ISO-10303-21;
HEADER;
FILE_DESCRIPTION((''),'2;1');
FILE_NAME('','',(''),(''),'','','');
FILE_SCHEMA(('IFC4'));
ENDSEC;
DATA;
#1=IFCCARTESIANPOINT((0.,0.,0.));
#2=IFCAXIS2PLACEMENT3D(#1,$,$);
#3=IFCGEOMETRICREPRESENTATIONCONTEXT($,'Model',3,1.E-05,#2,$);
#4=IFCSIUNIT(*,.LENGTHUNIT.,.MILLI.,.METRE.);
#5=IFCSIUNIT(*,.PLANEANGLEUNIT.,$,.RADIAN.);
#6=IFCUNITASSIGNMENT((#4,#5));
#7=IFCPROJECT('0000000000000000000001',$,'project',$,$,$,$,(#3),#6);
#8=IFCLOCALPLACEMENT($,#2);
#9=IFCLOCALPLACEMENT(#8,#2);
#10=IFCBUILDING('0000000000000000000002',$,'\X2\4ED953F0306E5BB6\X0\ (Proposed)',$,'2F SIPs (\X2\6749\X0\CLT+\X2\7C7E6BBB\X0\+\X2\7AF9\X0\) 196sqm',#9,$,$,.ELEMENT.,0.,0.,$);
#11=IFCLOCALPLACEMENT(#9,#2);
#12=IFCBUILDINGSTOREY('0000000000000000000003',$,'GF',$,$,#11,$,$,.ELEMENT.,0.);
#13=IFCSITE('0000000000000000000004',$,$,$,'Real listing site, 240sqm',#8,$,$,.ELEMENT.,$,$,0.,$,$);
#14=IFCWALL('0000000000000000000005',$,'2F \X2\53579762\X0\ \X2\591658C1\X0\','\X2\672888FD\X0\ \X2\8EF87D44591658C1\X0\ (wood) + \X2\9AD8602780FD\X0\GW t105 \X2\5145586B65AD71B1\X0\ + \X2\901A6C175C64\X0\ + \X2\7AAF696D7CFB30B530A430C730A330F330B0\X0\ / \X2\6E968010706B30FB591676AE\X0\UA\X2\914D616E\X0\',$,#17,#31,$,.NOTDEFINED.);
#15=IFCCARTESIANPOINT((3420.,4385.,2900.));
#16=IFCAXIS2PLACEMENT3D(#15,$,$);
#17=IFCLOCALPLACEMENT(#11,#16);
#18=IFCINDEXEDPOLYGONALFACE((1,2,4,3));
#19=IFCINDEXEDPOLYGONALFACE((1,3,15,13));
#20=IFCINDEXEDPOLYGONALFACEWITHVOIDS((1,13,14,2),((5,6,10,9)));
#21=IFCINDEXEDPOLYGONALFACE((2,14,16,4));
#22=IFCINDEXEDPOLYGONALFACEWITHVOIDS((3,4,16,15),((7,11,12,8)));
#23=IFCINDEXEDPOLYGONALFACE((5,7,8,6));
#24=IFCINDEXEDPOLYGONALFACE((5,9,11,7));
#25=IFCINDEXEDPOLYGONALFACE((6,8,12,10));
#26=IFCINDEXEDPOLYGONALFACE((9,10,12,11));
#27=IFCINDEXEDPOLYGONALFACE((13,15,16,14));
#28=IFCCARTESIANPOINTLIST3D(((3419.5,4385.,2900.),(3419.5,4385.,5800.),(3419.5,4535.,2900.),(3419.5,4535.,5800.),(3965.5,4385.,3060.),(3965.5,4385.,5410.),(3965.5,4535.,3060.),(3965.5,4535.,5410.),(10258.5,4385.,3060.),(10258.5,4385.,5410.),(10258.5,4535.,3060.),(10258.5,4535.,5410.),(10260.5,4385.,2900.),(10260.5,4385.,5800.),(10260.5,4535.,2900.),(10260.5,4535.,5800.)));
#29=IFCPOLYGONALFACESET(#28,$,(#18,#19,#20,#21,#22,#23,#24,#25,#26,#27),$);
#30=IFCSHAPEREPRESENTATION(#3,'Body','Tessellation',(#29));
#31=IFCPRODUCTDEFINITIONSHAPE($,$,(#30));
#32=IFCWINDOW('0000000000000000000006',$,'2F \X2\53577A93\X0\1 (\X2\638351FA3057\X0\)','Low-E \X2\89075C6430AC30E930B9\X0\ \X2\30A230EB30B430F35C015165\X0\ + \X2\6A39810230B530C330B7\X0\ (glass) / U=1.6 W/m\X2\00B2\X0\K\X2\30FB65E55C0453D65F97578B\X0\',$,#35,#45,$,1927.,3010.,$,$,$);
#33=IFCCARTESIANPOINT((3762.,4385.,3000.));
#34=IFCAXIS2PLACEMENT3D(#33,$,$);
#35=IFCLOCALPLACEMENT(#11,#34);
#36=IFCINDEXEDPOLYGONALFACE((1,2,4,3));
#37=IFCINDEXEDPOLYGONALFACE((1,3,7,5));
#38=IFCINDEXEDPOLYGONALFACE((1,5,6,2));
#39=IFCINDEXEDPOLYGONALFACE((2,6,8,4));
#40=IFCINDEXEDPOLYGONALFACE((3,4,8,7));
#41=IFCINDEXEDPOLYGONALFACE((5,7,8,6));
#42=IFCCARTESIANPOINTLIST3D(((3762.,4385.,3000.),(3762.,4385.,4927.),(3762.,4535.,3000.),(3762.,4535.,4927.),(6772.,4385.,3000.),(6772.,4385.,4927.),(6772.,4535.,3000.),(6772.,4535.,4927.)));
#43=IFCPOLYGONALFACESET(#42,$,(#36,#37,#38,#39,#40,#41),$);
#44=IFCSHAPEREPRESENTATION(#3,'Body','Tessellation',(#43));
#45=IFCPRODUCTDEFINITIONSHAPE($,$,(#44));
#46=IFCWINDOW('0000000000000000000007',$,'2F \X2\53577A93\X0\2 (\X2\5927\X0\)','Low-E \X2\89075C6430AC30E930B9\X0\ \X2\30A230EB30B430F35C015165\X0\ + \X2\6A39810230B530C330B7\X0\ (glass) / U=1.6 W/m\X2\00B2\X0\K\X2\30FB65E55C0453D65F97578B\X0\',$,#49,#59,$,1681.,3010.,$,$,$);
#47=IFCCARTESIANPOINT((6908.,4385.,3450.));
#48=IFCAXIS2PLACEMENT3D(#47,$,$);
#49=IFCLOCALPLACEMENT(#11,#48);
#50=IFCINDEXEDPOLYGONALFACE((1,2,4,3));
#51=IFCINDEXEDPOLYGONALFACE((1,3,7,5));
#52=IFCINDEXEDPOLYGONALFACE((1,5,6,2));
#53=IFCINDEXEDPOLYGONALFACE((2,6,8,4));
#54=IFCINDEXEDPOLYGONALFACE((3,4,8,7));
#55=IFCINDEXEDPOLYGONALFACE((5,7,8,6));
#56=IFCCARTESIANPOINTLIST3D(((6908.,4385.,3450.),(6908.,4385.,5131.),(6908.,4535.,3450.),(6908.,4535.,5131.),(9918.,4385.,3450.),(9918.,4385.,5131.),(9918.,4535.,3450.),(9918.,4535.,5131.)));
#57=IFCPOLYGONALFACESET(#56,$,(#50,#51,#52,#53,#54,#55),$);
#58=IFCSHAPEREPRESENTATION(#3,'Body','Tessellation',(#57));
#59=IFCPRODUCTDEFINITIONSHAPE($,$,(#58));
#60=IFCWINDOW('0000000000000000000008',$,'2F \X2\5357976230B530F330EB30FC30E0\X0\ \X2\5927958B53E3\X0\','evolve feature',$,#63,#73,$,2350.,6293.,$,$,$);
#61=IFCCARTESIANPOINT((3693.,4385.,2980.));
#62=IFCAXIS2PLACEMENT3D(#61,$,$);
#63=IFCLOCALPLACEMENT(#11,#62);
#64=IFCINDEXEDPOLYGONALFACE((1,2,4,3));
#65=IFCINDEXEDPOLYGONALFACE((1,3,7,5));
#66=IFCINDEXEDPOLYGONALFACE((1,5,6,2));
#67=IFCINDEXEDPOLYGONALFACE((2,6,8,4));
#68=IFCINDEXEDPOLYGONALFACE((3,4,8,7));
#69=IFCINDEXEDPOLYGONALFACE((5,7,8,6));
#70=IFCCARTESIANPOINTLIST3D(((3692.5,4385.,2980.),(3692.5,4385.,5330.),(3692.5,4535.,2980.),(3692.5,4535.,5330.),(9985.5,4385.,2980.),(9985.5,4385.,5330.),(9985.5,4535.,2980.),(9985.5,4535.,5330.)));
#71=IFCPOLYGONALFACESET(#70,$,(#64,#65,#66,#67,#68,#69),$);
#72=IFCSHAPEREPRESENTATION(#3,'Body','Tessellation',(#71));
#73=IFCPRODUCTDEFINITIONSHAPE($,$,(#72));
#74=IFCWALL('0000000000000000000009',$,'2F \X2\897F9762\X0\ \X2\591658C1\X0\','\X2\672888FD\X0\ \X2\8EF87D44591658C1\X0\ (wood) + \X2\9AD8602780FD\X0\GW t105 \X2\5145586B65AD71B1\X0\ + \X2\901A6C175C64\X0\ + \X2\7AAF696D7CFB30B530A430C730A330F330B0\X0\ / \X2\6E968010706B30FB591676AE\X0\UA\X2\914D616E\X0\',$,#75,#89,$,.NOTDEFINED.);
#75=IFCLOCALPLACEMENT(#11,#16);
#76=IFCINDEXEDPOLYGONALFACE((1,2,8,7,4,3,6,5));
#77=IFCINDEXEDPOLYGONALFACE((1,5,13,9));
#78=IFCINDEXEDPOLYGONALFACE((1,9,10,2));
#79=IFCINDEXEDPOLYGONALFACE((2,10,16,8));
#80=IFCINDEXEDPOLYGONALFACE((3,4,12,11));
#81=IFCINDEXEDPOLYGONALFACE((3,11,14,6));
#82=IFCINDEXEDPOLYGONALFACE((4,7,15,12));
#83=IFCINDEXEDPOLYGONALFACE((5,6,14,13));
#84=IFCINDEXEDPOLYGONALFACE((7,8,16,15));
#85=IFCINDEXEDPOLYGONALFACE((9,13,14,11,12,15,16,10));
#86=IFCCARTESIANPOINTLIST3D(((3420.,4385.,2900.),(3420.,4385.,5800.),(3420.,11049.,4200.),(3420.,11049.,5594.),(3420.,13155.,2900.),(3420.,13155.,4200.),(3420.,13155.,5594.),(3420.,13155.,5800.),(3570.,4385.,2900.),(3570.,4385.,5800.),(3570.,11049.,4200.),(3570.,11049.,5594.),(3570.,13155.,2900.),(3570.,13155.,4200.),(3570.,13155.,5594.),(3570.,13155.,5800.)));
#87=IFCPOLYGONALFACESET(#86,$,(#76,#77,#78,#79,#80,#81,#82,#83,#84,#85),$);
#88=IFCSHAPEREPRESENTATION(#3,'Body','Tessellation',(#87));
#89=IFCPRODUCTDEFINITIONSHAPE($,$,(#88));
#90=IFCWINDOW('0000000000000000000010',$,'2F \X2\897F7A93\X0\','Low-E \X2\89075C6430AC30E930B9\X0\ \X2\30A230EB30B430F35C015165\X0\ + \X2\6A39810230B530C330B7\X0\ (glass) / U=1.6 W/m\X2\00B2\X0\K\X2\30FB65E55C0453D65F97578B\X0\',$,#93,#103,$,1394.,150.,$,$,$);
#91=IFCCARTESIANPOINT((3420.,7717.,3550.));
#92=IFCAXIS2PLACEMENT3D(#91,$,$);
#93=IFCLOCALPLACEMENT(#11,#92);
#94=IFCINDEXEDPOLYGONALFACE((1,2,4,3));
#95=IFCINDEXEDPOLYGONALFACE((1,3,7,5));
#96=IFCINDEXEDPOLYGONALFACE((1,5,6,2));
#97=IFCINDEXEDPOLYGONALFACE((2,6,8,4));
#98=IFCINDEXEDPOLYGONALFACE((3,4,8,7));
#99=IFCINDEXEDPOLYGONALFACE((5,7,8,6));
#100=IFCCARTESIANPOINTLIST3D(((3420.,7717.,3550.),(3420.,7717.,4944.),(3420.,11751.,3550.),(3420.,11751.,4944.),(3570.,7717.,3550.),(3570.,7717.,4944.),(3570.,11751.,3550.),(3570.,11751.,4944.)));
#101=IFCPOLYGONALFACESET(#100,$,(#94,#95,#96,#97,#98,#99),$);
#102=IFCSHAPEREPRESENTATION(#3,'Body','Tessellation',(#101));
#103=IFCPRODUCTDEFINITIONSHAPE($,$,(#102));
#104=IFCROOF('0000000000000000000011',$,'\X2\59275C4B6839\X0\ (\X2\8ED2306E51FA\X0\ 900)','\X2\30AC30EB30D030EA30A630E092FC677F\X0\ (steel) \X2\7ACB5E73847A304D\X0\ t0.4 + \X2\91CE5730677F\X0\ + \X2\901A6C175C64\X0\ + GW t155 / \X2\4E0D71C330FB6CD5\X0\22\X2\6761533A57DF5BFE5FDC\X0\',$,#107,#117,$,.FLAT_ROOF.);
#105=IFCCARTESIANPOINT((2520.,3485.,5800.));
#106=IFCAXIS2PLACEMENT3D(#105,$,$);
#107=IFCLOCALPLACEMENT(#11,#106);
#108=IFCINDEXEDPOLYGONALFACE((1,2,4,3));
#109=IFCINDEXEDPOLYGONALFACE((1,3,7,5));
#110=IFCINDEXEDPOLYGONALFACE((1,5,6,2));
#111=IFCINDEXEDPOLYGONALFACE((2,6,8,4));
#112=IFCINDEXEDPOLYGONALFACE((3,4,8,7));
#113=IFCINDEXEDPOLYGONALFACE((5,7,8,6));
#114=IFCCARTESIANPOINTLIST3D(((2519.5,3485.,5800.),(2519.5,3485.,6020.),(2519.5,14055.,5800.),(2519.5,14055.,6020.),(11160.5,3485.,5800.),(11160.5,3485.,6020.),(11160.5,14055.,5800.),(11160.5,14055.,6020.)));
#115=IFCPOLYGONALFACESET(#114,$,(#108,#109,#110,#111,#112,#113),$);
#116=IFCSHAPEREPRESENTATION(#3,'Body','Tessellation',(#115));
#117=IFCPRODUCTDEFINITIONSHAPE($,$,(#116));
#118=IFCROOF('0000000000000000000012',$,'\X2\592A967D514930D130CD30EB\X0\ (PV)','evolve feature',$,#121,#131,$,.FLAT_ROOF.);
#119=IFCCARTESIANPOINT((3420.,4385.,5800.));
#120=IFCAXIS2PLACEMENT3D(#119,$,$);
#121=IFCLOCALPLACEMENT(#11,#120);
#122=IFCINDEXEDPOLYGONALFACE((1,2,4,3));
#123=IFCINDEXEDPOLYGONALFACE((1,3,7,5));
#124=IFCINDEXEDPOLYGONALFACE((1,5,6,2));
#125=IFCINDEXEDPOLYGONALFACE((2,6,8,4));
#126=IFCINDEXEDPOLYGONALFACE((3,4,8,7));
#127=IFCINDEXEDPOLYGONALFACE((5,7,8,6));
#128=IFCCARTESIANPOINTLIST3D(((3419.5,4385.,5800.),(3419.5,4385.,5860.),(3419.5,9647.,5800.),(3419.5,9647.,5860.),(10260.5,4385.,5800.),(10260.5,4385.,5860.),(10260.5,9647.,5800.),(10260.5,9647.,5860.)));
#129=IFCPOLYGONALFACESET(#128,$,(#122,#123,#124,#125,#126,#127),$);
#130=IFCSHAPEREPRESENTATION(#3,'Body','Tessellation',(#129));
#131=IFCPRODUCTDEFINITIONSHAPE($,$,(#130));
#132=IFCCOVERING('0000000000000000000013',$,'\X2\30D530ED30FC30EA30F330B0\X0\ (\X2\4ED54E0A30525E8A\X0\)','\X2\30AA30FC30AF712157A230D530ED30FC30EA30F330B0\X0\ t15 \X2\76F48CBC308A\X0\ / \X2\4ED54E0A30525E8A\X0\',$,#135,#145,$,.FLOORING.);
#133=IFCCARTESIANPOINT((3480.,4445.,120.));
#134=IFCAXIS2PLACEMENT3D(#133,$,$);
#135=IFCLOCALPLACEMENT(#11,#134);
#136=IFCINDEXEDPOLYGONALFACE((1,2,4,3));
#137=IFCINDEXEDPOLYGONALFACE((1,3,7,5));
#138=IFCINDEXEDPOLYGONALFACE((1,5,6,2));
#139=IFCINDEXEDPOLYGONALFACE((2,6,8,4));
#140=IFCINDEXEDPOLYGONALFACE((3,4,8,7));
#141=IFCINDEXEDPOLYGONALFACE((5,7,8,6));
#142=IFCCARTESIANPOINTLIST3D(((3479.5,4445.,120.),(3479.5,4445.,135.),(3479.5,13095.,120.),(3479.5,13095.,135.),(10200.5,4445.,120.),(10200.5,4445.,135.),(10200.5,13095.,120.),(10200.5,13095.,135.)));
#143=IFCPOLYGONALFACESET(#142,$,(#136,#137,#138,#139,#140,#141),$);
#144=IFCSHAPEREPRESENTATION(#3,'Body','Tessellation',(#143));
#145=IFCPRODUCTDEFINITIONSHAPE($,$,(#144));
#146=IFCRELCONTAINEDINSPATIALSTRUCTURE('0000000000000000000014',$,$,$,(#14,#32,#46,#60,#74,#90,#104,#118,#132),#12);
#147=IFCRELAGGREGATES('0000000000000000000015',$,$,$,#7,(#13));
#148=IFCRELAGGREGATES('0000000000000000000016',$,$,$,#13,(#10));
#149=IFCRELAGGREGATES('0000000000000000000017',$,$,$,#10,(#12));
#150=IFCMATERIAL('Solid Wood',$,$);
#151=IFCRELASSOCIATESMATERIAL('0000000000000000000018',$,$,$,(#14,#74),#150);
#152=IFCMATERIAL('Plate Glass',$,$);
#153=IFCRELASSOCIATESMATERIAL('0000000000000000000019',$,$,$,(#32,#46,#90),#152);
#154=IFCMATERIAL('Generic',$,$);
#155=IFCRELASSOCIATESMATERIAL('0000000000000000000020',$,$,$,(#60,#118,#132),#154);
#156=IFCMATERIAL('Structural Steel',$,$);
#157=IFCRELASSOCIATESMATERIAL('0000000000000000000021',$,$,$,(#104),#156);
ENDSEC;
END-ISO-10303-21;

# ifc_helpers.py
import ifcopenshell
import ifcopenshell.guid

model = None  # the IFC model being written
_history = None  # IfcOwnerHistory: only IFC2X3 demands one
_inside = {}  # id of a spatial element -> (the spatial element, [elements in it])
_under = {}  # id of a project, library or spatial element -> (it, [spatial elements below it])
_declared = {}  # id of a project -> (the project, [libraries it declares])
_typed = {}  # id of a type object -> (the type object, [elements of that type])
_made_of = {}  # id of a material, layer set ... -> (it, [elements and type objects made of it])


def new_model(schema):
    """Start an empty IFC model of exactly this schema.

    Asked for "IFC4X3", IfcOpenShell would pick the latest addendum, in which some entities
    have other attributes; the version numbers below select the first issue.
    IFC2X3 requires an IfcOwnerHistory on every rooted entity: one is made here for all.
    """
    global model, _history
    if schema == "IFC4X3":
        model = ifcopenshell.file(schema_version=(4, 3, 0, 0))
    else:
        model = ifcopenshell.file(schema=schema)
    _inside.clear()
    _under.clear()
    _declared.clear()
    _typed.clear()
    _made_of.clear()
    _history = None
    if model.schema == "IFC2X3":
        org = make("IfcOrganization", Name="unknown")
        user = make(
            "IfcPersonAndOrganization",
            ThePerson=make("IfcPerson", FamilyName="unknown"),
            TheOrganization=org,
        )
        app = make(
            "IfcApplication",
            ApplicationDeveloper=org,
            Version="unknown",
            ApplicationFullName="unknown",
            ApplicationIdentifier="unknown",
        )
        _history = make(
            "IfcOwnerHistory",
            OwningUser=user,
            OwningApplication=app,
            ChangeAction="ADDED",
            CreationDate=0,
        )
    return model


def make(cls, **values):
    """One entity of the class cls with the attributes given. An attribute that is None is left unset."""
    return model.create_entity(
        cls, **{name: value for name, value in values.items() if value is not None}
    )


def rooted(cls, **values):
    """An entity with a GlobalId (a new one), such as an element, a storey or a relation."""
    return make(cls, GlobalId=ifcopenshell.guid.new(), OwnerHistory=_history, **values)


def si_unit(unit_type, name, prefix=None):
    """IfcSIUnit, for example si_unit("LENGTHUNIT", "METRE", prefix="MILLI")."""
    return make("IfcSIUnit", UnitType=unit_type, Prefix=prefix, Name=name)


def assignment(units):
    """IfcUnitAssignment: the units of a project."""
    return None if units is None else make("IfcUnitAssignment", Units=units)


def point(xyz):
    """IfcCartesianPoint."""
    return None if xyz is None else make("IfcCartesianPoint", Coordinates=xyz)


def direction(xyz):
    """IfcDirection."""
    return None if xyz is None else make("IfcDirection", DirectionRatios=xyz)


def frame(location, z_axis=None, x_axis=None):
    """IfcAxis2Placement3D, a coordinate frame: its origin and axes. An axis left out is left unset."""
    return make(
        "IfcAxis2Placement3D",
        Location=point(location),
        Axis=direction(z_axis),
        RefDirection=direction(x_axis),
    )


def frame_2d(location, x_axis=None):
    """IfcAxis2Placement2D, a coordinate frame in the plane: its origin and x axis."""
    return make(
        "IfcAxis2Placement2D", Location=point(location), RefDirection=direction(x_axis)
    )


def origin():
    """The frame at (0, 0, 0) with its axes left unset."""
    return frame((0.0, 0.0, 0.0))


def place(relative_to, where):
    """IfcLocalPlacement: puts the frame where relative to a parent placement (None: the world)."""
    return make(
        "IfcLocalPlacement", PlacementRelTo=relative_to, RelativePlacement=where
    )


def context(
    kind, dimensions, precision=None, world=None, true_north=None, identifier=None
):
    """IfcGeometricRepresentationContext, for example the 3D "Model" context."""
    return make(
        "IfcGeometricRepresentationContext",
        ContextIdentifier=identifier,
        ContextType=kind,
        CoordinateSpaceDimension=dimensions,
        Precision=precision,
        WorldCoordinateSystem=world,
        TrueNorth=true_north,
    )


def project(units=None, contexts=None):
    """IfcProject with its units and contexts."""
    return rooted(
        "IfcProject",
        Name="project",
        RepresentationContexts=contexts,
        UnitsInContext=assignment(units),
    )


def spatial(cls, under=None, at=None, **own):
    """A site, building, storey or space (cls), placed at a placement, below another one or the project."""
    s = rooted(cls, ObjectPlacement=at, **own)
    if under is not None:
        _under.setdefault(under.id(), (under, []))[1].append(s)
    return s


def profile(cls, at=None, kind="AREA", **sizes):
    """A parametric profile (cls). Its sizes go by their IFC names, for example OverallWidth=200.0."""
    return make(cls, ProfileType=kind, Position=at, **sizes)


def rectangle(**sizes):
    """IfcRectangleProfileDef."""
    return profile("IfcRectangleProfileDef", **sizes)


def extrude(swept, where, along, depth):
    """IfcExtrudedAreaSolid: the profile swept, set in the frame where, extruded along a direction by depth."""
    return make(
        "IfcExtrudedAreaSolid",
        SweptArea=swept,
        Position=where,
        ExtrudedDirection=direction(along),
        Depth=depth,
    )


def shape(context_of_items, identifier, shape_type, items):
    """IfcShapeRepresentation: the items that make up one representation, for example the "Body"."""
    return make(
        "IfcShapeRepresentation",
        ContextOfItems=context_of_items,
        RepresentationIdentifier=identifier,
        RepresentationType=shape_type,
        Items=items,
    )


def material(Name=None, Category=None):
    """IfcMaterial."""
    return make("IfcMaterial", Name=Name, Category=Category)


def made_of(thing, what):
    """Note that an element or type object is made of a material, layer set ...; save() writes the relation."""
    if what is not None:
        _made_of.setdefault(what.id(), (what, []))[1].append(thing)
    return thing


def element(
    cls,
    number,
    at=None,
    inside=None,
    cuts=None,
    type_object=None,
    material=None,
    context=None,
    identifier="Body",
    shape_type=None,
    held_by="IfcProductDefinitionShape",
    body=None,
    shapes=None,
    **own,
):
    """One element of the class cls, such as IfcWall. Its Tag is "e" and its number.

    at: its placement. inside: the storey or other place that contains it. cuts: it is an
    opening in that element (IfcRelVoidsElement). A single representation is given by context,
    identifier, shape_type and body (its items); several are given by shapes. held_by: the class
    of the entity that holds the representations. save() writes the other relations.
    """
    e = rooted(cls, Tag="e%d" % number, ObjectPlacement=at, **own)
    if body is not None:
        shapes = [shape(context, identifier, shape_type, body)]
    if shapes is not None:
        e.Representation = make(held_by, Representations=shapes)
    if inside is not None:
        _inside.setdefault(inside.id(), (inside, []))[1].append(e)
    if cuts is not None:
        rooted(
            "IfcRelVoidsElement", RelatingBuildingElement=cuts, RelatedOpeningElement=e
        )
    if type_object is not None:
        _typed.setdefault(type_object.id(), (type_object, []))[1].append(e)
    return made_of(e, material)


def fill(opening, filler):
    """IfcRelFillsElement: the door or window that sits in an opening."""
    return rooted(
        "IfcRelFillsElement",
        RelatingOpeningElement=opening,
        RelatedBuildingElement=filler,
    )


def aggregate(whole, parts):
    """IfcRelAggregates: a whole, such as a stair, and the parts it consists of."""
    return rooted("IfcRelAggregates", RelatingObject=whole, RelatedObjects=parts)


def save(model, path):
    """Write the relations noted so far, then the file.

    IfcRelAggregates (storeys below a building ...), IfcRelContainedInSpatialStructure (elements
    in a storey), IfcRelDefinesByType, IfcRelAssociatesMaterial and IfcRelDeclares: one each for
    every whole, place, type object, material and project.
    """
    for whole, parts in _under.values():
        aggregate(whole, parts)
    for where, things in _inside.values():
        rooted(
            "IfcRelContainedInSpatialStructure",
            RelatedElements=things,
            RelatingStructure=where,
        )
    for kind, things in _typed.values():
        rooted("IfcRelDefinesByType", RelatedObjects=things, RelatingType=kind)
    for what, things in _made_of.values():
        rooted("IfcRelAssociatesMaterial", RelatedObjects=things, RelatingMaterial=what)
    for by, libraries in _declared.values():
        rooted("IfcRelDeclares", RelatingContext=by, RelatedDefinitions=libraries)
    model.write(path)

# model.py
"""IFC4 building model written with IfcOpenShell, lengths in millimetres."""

from ifc_helpers import new_model, si_unit, frame, frame_2d, origin, place, context, project, spatial, rectangle, extrude, material, element, fill, save


model = new_model("IFC4")

# Units and contexts
model_context = context("Model", 3, precision=1e-05, world=origin())
ifc_project = project(units=[si_unit("LENGTHUNIT", "METRE", prefix="MILLI"), si_unit("PLANEANGLEUNIT", "RADIAN")], contexts=[model_context])

# Site, building, storey
site_placement = place(None, origin())
site = spatial("IfcSite", under=ifc_project, at=site_placement, ObjectType="Real listing site, 240sqm", CompositionType="ELEMENT", RefElevation=0.0)
building_placement = place(site_placement, origin())
building = spatial("IfcBuilding", under=site, at=building_placement, Name="仙台の家 (Proposed)", ObjectType="2F SIPs (杉CLT+籾殻+竹) 196sqm", CompositionType="ELEMENT", ElevationOfRefHeight=0.0, ElevationOfTerrain=0.0)
storey_placement = place(building_placement, origin())
storey = spatial("IfcBuildingStorey", under=building, at=storey_placement, Name="GF", CompositionType="ELEMENT", Elevation=0.0)

# Shared definitions
ifc_material_1 = material(Name="Solid Wood")

# Shared definitions
ifc_material_2 = material(Name="Plate Glass")
ifc_material_3 = material(Name="Generic")

# Wall, openings, windows
wall_1_placement = place(storey_placement, frame((3420.0, 4385.0, 2900.0)))
wall_1 = element("IfcWall", 1, at=wall_1_placement, inside=storey, material=ifc_material_1, Name="2F 南面 外壁", Description="木製 軸組外壁 (wood) + 高性能GW t105 充填断熱 + 通気層 + 窯業系サイディング / 準耐火・外皮UA配慮", PredefinedType="NOTDEFINED", context=model_context, shape_type="SweptSolid", body=[
    extrude(rectangle(XDim=6841.0, YDim=150.0, at=frame_2d((3420.0, 75.0))), frame((3420.0, 4385.0, 2900.0)), (0.0, 0.0, 1.0), 2900.0),
])
opening_1_placement = place(storey_placement, frame((3762.0, 4385.0, 3000.0)))
opening_1 = element("IfcOpeningElement", 2, at=opening_1_placement, cuts=wall_1, PredefinedType="NOTDEFINED", context=model_context, shape_type="SweptSolid", body=[
    extrude(rectangle(XDim=3010.0, YDim=150.0, at=frame_2d((1505.0, 75.0))), frame((3762.0, 4385.0, 3000.0)), (0.0, 0.0, 1.0), 1927.0),
])
opening_2_placement = place(storey_placement, frame((6908.0, 4385.0, 3450.0)))
opening_2 = element("IfcOpeningElement", 3, at=opening_2_placement, cuts=wall_1, PredefinedType="NOTDEFINED", context=model_context, shape_type="SweptSolid", body=[
    extrude(rectangle(XDim=3010.0, YDim=150.0, at=frame_2d((1505.0, 75.0))), frame((6908.0, 4385.0, 3450.0)), (0.0, 0.0, 1.0), 1681.0),
])
opening_3_placement = place(storey_placement, frame((3693.0, 4385.0, 2980.0)))
opening_3 = element("IfcOpeningElement", 4, at=opening_3_placement, cuts=wall_1, PredefinedType="NOTDEFINED", context=model_context, shape_type="SweptSolid", body=[
    extrude(rectangle(XDim=6293.0, YDim=150.0, at=frame_2d((3146.0, 75.0))), frame((3693.0, 4385.0, 2980.0)), (0.0, 0.0, 1.0), 2350.0),
])
window_1_placement = place(storey_placement, frame((3762.0, 4385.0, 3000.0)))
window_1 = element("IfcWindow", 5, at=window_1_placement, inside=storey, material=ifc_material_2, Name="2F 南窓1 (掃出し)", Description="Low-E 複層ガラス アルゴン封入 + 樹脂サッシ (glass) / U=1.6 W/m²K・日射取得型", OverallHeight=1927.0, OverallWidth=3010.0, context=model_context, shape_type="SweptSolid", body=[
    extrude(rectangle(XDim=3010.0, YDim=150.0, at=frame_2d((1505.0, 75.0))), frame((3762.0, 4385.0, 3000.0)), (0.0, 0.0, 1.0), 1927.0),
])
fill(opening_1, window_1)
window_2_placement = place(storey_placement, frame((6908.0, 4385.0, 3450.0)))
window_2 = element("IfcWindow", 6, at=window_2_placement, inside=storey, material=ifc_material_2, Name="2F 南窓2 (大)", Description="Low-E 複層ガラス アルゴン封入 + 樹脂サッシ (glass) / U=1.6 W/m²K・日射取得型", OverallHeight=1681.0, OverallWidth=3010.0, context=model_context, shape_type="SweptSolid", body=[
    extrude(rectangle(XDim=3010.0, YDim=150.0, at=frame_2d((1505.0, 75.0))), frame((6908.0, 4385.0, 3450.0)), (0.0, 0.0, 1.0), 1681.0),
])
fill(opening_2, window_2)
window_3_placement = place(storey_placement, frame((3693.0, 4385.0, 2980.0)))
window_3 = element("IfcWindow", 7, at=window_3_placement, inside=storey, material=ifc_material_3, Name="2F 南面サンルーム 大開口", Description="evolve feature", OverallHeight=2350.0, OverallWidth=6293.0, context=model_context, shape_type="SweptSolid", body=[
    extrude(rectangle(XDim=6293.0, YDim=150.0, at=frame_2d((3146.0, 75.0))), frame((3693.0, 4385.0, 2980.0)), (0.0, 0.0, 1.0), 2350.0),
])
fill(opening_3, window_3)

# Wall, opening, window
wall_2_placement = place(storey_placement, frame((3420.0, 4385.0, 2900.0)))
wall_2 = element("IfcWall", 8, at=wall_2_placement, inside=storey, material=ifc_material_1, Name="2F 西面 外壁", Description="木製 軸組外壁 (wood) + 高性能GW t105 充填断熱 + 通気層 + 窯業系サイディング / 準耐火・外皮UA配慮", PredefinedType="NOTDEFINED", context=model_context, shape_type="SweptSolid", body=[
    extrude(rectangle(XDim=150.0, YDim=8770.0, at=frame_2d((75.0, 4385.0))), frame((3420.0, 4385.0, 2900.0)), (0.0, 0.0, 1.0), 2900.0),
])
opening_4_placement = place(storey_placement, frame((3420.0, 7717.0, 3550.0)))
opening_4 = element("IfcOpeningElement", 9, at=opening_4_placement, cuts=wall_2, PredefinedType="NOTDEFINED", context=model_context, shape_type="SweptSolid", body=[
    extrude(rectangle(XDim=150.0, YDim=4034.0, at=frame_2d((75.0, 2017.0))), frame((3420.0, 7717.0, 3550.0)), (0.0, 0.0, 1.0), 1394.0),
])
window_4_placement = place(storey_placement, frame((3420.0, 7717.0, 3550.0)))
window_4 = element("IfcWindow", 10, at=window_4_placement, inside=storey, material=ifc_material_2, Name="2F 西窓", Description="Low-E 複層ガラス アルゴン封入 + 樹脂サッシ (glass) / U=1.6 W/m²K・日射取得型", OverallHeight=1394.0, OverallWidth=150.0, context=model_context, shape_type="SweptSolid", body=[
    extrude(rectangle(XDim=150.0, YDim=4034.0, at=frame_2d((75.0, 2017.0))), frame((3420.0, 7717.0, 3550.0)), (0.0, 0.0, 1.0), 1394.0),
])
fill(opening_4, window_4)

# Roofs
ifc_material_4 = material(Name="Structural Steel")
roof_1_placement = place(storey_placement, frame((2520.0, 3485.0, 5800.0)))
element("IfcRoof", 11, at=roof_1_placement, inside=storey, material=ifc_material_4, Name="大屋根 (軒の出 900)", Description="ガルバリウム鋼板 (steel) 立平葺き t0.4 + 野地板 + 通気層 + GW t155 / 不燃・法22条区域対応", PredefinedType="FLAT_ROOF", context=model_context, shape_type="SweptSolid", body=[
    extrude(rectangle(XDim=8641.0, YDim=10570.0, at=frame_2d((4320.0, 5285.0))), frame((2520.0, 3485.0, 5800.0)), (0.0, 0.0, 1.0), 220.0),
])
roof_2_placement = place(storey_placement, frame((3420.0, 4385.0, 5800.0)))
element("IfcRoof", 12, at=roof_2_placement, inside=storey, material=ifc_material_3, Name="太陽光パネル (PV)", Description="evolve feature", PredefinedType="FLAT_ROOF", context=model_context, shape_type="SweptSolid", body=[
    extrude(rectangle(XDim=6841.0, YDim=5262.0, at=frame_2d((3420.0, 2631.0))), frame((3420.0, 4385.0, 5800.0)), (0.0, 0.0, 1.0), 60.0),
])

# Covering
covering_placement = place(storey_placement, frame((3480.0, 4445.0, 120.0)))
element("IfcCovering", 13, at=covering_placement, inside=storey, material=ifc_material_3, Name="フローリング (仕上げ床)", Description="オーク無垢フローリング t15 直貼り / 仕上げ床", PredefinedType="FLOORING", context=model_context, shape_type="SweptSolid", body=[
    extrude(rectangle(XDim=6721.0, YDim=8650.0, at=frame_2d((3360.0, 4325.0))), frame((3480.0, 4445.0, 120.0)), (0.0, 0.0, 1.0), 15.0),
])

save(model, "model.ifc")
